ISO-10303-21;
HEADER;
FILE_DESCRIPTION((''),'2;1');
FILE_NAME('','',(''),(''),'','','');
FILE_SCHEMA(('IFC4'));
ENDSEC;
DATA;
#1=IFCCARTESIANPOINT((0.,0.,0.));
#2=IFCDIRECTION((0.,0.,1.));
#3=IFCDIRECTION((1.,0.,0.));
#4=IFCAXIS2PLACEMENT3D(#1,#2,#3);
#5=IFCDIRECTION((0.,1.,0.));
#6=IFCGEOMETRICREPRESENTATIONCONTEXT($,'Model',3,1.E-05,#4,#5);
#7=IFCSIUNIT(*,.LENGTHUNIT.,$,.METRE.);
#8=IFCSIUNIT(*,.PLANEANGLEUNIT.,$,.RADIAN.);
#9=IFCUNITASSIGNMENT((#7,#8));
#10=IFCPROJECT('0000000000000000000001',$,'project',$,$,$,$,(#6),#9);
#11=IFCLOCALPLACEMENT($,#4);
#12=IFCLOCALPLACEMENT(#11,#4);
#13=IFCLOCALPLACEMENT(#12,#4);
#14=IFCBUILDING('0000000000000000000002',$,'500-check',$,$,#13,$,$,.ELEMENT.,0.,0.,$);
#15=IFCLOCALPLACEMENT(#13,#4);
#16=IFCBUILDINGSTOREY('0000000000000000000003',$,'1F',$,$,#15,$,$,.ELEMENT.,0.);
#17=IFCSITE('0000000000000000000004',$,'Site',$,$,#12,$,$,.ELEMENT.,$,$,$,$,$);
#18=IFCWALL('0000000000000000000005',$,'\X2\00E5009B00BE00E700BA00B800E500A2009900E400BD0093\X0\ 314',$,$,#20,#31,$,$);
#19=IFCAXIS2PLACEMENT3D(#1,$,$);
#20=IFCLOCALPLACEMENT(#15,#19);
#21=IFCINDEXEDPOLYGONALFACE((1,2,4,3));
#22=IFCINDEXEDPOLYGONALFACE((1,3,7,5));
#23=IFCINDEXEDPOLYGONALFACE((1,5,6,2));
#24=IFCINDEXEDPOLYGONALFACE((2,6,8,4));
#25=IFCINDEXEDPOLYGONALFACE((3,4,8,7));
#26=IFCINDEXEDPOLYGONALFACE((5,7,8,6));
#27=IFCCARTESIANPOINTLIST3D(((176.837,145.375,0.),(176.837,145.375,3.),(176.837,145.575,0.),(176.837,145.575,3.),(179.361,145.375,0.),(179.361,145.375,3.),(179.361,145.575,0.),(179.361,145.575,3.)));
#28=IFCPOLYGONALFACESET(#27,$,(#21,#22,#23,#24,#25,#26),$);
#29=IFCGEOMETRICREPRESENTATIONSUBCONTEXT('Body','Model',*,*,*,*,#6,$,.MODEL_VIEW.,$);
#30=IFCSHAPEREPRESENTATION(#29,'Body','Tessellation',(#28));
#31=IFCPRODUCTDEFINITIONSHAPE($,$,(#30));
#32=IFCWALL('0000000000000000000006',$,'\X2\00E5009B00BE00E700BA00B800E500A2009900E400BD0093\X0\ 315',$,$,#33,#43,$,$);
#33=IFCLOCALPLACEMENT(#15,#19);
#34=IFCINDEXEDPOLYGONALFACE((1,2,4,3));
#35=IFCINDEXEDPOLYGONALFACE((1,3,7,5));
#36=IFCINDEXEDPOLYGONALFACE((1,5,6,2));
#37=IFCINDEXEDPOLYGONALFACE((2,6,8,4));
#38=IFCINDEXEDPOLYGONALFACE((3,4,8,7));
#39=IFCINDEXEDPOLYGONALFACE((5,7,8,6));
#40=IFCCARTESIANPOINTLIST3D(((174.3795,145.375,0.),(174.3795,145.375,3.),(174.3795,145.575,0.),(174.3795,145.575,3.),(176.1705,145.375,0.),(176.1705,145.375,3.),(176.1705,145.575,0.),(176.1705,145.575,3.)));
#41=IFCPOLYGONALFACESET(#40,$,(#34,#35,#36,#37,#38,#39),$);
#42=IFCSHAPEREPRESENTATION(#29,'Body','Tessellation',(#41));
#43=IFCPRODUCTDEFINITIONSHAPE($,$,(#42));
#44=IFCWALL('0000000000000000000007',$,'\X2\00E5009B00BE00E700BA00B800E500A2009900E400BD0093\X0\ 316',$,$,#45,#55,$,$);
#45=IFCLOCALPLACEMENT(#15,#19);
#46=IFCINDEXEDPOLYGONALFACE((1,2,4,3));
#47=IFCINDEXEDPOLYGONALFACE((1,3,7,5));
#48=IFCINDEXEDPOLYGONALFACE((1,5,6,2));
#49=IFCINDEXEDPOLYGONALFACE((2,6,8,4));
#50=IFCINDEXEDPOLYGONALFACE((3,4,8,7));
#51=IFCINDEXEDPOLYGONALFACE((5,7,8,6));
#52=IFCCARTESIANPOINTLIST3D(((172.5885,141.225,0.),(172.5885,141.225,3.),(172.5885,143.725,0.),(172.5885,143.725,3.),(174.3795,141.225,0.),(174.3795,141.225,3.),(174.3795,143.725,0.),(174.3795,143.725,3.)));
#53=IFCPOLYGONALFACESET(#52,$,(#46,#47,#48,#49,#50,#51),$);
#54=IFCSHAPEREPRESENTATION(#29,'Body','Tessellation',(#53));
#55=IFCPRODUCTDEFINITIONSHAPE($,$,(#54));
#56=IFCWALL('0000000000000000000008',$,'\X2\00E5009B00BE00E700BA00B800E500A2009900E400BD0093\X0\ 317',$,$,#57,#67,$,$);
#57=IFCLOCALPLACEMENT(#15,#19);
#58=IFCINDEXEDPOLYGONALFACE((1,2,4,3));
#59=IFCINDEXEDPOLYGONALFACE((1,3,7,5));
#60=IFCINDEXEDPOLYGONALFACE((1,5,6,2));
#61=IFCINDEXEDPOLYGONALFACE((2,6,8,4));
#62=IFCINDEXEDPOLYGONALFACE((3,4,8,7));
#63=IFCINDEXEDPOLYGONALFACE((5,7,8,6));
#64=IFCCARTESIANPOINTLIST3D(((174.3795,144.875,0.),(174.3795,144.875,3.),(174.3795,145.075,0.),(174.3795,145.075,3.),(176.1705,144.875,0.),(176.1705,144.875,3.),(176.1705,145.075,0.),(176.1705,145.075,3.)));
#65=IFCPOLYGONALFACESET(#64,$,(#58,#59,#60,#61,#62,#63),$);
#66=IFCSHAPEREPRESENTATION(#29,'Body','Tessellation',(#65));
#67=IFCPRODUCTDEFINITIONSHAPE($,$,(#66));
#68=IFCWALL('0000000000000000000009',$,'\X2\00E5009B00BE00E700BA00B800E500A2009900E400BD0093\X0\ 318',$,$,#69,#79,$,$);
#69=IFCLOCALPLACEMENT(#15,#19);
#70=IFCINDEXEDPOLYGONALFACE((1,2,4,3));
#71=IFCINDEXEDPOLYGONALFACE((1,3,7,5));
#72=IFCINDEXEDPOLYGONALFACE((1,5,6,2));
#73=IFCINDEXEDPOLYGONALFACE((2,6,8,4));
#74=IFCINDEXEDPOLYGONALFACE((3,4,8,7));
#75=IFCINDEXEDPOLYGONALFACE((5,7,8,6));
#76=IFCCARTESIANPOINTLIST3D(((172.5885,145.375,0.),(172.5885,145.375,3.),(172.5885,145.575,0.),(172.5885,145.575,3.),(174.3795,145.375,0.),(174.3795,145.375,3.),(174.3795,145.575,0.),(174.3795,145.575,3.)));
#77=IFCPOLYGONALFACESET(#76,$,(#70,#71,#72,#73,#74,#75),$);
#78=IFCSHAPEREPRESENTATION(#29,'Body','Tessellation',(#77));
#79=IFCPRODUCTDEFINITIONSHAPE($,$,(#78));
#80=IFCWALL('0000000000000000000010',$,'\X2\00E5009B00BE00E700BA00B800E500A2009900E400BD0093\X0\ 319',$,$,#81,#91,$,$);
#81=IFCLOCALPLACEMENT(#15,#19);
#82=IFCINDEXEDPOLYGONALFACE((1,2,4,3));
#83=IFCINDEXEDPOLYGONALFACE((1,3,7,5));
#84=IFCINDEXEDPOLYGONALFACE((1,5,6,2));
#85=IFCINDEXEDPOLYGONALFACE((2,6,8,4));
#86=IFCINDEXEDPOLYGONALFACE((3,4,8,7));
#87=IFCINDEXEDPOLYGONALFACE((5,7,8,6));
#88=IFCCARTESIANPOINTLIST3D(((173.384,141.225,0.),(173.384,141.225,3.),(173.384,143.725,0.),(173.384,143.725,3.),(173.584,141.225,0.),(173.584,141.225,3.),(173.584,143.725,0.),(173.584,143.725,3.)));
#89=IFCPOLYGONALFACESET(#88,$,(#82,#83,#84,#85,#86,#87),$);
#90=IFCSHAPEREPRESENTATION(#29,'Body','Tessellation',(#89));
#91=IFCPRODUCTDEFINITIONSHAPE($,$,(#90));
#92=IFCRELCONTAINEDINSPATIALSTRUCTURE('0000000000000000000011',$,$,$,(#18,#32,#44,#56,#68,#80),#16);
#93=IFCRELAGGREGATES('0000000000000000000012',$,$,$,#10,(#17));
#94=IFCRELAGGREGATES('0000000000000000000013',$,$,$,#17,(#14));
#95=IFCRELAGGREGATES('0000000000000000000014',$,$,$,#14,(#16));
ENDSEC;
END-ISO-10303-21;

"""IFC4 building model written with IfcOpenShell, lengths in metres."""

from ifc_helpers import new_model, si_unit, direction, frame, frame_2d, origin_with_axes, place, context, subcontext, project, spatial, rectangle, extrude, element, save


model = new_model("IFC4")

# Units and contexts
model_context = context("Model", 3, precision=1e-05, world=origin_with_axes(), true_north=direction((0.0, 1.0, 0.0)))
body_context = subcontext(model_context, "Body", "Model", "MODEL_VIEW")
ifc_project = project(units=[si_unit("LENGTHUNIT", "METRE"), si_unit("PLANEANGLEUNIT", "RADIAN")], contexts=[model_context])

# Site, building, storey
placement = place(None, origin_with_axes())
site_placement = place(placement, origin_with_axes())
site = spatial("IfcSite", under=ifc_project, at=site_placement, Name="Site", CompositionType="ELEMENT")
building_placement = place(site_placement, origin_with_axes())
building = spatial("IfcBuilding", under=site, at=building_placement, Name="500-check", CompositionType="ELEMENT", ElevationOfRefHeight=0.0, ElevationOfTerrain=0.0)
storey_placement = place(building_placement, origin_with_axes())
storey = spatial("IfcBuildingStorey", under=building, at=storey_placement, Name="1F", CompositionType="ELEMENT", Elevation=0.0)

# Walls
for number, where, z_axis, x_axis, name in (
    (1, (178.099, 145.475, 0.0), (0.0, 0.0, 1.0), (-1.0, 0.0, 0.0), "å\u009b¾çº¸å¢\u0099ä½\u0093 314"),
):
    element("IfcWall", number, at=place(storey_placement, frame(where, z_axis=z_axis, x_axis=x_axis)), inside=storey, Name=name, context=body_context, shape_type="SweptSolid", body=[
        extrude(rectangle(XDim=2.524, YDim=0.2, at=frame_2d((0.0, 0.0), x_axis=(1.0, 0.0, 0.0))), frame((0.0, 0.0, 0.0), z_axis=(0.0, 0.0, 1.0)), (0.0, 0.0, 1.0), 3.0),
    ])
wall_1_placement = place(storey_placement, frame((175.275, 145.475, 0.0), z_axis=(0.0, 0.0, 1.0), x_axis=(-1.0, 0.0, 0.0)))
element("IfcWall", 2, at=wall_1_placement, inside=storey, Name="å\u009b¾çº¸å¢\u0099ä½\u0093 315", context=body_context, shape_type="SweptSolid", body=[
    extrude(rectangle(XDim=1.791, YDim=0.2, at=frame_2d((0.0, 0.0), x_axis=(1.0, 0.0, 0.0))), frame((0.0, 0.0, 0.0), z_axis=(0.0, 0.0, 1.0)), (0.0, 0.0, 1.0), 3.0),
])
wall_2_placement = place(storey_placement, frame((173.484, 142.475, 0.0), z_axis=(0.0, 0.0, 1.0), x_axis=(1.0, 0.0, 0.0)))
element("IfcWall", 3, at=wall_2_placement, inside=storey, Name="å\u009b¾çº¸å¢\u0099ä½\u0093 316", context=body_context, shape_type="SweptSolid", body=[
    extrude(rectangle(XDim=1.791, YDim=2.5, at=frame_2d((0.0, 0.0), x_axis=(1.0, 0.0, 0.0))), frame((0.0, 0.0, 0.0), z_axis=(0.0, 0.0, 1.0)), (0.0, 0.0, 1.0), 3.0),
])
for number, where, z_axis, x_axis, name in (
    (4, (175.275, 144.975, 0.0), (0.0, 0.0, 1.0), (-1.0, 0.0, 0.0), "å\u009b¾çº¸å¢\u0099ä½\u0093 317"),
    (5, (173.484, 145.475, 0.0), (0.0, 0.0, 1.0), (1.0, 0.0, 0.0), "å\u009b¾çº¸å¢\u0099ä½\u0093 318"),
):
    element("IfcWall", number, at=place(storey_placement, frame(where, z_axis=z_axis, x_axis=x_axis)), inside=storey, Name=name, context=body_context, shape_type="SweptSolid", body=[
        extrude(rectangle(XDim=1.791, YDim=0.2, at=frame_2d((0.0, 0.0), x_axis=(1.0, 0.0, 0.0))), frame((0.0, 0.0, 0.0), z_axis=(0.0, 0.0, 1.0)), (0.0, 0.0, 1.0), 3.0),
    ])
wall_3_placement = place(storey_placement, frame((173.484, 142.475, 0.0), z_axis=(0.0, 0.0, 1.0), x_axis=(0.0, 1.0, 0.0)))
element("IfcWall", 6, at=wall_3_placement, inside=storey, Name="å\u009b¾çº¸å¢\u0099ä½\u0093 319", context=body_context, shape_type="SweptSolid", body=[
    extrude(rectangle(XDim=2.5, YDim=0.2, at=frame_2d((0.0, 0.0), x_axis=(1.0, 0.0, 0.0))), frame((0.0, 0.0, 0.0), z_axis=(0.0, 0.0, 1.0)), (0.0, 0.0, 1.0), 3.0),
])

save(model, "model.ifc")
